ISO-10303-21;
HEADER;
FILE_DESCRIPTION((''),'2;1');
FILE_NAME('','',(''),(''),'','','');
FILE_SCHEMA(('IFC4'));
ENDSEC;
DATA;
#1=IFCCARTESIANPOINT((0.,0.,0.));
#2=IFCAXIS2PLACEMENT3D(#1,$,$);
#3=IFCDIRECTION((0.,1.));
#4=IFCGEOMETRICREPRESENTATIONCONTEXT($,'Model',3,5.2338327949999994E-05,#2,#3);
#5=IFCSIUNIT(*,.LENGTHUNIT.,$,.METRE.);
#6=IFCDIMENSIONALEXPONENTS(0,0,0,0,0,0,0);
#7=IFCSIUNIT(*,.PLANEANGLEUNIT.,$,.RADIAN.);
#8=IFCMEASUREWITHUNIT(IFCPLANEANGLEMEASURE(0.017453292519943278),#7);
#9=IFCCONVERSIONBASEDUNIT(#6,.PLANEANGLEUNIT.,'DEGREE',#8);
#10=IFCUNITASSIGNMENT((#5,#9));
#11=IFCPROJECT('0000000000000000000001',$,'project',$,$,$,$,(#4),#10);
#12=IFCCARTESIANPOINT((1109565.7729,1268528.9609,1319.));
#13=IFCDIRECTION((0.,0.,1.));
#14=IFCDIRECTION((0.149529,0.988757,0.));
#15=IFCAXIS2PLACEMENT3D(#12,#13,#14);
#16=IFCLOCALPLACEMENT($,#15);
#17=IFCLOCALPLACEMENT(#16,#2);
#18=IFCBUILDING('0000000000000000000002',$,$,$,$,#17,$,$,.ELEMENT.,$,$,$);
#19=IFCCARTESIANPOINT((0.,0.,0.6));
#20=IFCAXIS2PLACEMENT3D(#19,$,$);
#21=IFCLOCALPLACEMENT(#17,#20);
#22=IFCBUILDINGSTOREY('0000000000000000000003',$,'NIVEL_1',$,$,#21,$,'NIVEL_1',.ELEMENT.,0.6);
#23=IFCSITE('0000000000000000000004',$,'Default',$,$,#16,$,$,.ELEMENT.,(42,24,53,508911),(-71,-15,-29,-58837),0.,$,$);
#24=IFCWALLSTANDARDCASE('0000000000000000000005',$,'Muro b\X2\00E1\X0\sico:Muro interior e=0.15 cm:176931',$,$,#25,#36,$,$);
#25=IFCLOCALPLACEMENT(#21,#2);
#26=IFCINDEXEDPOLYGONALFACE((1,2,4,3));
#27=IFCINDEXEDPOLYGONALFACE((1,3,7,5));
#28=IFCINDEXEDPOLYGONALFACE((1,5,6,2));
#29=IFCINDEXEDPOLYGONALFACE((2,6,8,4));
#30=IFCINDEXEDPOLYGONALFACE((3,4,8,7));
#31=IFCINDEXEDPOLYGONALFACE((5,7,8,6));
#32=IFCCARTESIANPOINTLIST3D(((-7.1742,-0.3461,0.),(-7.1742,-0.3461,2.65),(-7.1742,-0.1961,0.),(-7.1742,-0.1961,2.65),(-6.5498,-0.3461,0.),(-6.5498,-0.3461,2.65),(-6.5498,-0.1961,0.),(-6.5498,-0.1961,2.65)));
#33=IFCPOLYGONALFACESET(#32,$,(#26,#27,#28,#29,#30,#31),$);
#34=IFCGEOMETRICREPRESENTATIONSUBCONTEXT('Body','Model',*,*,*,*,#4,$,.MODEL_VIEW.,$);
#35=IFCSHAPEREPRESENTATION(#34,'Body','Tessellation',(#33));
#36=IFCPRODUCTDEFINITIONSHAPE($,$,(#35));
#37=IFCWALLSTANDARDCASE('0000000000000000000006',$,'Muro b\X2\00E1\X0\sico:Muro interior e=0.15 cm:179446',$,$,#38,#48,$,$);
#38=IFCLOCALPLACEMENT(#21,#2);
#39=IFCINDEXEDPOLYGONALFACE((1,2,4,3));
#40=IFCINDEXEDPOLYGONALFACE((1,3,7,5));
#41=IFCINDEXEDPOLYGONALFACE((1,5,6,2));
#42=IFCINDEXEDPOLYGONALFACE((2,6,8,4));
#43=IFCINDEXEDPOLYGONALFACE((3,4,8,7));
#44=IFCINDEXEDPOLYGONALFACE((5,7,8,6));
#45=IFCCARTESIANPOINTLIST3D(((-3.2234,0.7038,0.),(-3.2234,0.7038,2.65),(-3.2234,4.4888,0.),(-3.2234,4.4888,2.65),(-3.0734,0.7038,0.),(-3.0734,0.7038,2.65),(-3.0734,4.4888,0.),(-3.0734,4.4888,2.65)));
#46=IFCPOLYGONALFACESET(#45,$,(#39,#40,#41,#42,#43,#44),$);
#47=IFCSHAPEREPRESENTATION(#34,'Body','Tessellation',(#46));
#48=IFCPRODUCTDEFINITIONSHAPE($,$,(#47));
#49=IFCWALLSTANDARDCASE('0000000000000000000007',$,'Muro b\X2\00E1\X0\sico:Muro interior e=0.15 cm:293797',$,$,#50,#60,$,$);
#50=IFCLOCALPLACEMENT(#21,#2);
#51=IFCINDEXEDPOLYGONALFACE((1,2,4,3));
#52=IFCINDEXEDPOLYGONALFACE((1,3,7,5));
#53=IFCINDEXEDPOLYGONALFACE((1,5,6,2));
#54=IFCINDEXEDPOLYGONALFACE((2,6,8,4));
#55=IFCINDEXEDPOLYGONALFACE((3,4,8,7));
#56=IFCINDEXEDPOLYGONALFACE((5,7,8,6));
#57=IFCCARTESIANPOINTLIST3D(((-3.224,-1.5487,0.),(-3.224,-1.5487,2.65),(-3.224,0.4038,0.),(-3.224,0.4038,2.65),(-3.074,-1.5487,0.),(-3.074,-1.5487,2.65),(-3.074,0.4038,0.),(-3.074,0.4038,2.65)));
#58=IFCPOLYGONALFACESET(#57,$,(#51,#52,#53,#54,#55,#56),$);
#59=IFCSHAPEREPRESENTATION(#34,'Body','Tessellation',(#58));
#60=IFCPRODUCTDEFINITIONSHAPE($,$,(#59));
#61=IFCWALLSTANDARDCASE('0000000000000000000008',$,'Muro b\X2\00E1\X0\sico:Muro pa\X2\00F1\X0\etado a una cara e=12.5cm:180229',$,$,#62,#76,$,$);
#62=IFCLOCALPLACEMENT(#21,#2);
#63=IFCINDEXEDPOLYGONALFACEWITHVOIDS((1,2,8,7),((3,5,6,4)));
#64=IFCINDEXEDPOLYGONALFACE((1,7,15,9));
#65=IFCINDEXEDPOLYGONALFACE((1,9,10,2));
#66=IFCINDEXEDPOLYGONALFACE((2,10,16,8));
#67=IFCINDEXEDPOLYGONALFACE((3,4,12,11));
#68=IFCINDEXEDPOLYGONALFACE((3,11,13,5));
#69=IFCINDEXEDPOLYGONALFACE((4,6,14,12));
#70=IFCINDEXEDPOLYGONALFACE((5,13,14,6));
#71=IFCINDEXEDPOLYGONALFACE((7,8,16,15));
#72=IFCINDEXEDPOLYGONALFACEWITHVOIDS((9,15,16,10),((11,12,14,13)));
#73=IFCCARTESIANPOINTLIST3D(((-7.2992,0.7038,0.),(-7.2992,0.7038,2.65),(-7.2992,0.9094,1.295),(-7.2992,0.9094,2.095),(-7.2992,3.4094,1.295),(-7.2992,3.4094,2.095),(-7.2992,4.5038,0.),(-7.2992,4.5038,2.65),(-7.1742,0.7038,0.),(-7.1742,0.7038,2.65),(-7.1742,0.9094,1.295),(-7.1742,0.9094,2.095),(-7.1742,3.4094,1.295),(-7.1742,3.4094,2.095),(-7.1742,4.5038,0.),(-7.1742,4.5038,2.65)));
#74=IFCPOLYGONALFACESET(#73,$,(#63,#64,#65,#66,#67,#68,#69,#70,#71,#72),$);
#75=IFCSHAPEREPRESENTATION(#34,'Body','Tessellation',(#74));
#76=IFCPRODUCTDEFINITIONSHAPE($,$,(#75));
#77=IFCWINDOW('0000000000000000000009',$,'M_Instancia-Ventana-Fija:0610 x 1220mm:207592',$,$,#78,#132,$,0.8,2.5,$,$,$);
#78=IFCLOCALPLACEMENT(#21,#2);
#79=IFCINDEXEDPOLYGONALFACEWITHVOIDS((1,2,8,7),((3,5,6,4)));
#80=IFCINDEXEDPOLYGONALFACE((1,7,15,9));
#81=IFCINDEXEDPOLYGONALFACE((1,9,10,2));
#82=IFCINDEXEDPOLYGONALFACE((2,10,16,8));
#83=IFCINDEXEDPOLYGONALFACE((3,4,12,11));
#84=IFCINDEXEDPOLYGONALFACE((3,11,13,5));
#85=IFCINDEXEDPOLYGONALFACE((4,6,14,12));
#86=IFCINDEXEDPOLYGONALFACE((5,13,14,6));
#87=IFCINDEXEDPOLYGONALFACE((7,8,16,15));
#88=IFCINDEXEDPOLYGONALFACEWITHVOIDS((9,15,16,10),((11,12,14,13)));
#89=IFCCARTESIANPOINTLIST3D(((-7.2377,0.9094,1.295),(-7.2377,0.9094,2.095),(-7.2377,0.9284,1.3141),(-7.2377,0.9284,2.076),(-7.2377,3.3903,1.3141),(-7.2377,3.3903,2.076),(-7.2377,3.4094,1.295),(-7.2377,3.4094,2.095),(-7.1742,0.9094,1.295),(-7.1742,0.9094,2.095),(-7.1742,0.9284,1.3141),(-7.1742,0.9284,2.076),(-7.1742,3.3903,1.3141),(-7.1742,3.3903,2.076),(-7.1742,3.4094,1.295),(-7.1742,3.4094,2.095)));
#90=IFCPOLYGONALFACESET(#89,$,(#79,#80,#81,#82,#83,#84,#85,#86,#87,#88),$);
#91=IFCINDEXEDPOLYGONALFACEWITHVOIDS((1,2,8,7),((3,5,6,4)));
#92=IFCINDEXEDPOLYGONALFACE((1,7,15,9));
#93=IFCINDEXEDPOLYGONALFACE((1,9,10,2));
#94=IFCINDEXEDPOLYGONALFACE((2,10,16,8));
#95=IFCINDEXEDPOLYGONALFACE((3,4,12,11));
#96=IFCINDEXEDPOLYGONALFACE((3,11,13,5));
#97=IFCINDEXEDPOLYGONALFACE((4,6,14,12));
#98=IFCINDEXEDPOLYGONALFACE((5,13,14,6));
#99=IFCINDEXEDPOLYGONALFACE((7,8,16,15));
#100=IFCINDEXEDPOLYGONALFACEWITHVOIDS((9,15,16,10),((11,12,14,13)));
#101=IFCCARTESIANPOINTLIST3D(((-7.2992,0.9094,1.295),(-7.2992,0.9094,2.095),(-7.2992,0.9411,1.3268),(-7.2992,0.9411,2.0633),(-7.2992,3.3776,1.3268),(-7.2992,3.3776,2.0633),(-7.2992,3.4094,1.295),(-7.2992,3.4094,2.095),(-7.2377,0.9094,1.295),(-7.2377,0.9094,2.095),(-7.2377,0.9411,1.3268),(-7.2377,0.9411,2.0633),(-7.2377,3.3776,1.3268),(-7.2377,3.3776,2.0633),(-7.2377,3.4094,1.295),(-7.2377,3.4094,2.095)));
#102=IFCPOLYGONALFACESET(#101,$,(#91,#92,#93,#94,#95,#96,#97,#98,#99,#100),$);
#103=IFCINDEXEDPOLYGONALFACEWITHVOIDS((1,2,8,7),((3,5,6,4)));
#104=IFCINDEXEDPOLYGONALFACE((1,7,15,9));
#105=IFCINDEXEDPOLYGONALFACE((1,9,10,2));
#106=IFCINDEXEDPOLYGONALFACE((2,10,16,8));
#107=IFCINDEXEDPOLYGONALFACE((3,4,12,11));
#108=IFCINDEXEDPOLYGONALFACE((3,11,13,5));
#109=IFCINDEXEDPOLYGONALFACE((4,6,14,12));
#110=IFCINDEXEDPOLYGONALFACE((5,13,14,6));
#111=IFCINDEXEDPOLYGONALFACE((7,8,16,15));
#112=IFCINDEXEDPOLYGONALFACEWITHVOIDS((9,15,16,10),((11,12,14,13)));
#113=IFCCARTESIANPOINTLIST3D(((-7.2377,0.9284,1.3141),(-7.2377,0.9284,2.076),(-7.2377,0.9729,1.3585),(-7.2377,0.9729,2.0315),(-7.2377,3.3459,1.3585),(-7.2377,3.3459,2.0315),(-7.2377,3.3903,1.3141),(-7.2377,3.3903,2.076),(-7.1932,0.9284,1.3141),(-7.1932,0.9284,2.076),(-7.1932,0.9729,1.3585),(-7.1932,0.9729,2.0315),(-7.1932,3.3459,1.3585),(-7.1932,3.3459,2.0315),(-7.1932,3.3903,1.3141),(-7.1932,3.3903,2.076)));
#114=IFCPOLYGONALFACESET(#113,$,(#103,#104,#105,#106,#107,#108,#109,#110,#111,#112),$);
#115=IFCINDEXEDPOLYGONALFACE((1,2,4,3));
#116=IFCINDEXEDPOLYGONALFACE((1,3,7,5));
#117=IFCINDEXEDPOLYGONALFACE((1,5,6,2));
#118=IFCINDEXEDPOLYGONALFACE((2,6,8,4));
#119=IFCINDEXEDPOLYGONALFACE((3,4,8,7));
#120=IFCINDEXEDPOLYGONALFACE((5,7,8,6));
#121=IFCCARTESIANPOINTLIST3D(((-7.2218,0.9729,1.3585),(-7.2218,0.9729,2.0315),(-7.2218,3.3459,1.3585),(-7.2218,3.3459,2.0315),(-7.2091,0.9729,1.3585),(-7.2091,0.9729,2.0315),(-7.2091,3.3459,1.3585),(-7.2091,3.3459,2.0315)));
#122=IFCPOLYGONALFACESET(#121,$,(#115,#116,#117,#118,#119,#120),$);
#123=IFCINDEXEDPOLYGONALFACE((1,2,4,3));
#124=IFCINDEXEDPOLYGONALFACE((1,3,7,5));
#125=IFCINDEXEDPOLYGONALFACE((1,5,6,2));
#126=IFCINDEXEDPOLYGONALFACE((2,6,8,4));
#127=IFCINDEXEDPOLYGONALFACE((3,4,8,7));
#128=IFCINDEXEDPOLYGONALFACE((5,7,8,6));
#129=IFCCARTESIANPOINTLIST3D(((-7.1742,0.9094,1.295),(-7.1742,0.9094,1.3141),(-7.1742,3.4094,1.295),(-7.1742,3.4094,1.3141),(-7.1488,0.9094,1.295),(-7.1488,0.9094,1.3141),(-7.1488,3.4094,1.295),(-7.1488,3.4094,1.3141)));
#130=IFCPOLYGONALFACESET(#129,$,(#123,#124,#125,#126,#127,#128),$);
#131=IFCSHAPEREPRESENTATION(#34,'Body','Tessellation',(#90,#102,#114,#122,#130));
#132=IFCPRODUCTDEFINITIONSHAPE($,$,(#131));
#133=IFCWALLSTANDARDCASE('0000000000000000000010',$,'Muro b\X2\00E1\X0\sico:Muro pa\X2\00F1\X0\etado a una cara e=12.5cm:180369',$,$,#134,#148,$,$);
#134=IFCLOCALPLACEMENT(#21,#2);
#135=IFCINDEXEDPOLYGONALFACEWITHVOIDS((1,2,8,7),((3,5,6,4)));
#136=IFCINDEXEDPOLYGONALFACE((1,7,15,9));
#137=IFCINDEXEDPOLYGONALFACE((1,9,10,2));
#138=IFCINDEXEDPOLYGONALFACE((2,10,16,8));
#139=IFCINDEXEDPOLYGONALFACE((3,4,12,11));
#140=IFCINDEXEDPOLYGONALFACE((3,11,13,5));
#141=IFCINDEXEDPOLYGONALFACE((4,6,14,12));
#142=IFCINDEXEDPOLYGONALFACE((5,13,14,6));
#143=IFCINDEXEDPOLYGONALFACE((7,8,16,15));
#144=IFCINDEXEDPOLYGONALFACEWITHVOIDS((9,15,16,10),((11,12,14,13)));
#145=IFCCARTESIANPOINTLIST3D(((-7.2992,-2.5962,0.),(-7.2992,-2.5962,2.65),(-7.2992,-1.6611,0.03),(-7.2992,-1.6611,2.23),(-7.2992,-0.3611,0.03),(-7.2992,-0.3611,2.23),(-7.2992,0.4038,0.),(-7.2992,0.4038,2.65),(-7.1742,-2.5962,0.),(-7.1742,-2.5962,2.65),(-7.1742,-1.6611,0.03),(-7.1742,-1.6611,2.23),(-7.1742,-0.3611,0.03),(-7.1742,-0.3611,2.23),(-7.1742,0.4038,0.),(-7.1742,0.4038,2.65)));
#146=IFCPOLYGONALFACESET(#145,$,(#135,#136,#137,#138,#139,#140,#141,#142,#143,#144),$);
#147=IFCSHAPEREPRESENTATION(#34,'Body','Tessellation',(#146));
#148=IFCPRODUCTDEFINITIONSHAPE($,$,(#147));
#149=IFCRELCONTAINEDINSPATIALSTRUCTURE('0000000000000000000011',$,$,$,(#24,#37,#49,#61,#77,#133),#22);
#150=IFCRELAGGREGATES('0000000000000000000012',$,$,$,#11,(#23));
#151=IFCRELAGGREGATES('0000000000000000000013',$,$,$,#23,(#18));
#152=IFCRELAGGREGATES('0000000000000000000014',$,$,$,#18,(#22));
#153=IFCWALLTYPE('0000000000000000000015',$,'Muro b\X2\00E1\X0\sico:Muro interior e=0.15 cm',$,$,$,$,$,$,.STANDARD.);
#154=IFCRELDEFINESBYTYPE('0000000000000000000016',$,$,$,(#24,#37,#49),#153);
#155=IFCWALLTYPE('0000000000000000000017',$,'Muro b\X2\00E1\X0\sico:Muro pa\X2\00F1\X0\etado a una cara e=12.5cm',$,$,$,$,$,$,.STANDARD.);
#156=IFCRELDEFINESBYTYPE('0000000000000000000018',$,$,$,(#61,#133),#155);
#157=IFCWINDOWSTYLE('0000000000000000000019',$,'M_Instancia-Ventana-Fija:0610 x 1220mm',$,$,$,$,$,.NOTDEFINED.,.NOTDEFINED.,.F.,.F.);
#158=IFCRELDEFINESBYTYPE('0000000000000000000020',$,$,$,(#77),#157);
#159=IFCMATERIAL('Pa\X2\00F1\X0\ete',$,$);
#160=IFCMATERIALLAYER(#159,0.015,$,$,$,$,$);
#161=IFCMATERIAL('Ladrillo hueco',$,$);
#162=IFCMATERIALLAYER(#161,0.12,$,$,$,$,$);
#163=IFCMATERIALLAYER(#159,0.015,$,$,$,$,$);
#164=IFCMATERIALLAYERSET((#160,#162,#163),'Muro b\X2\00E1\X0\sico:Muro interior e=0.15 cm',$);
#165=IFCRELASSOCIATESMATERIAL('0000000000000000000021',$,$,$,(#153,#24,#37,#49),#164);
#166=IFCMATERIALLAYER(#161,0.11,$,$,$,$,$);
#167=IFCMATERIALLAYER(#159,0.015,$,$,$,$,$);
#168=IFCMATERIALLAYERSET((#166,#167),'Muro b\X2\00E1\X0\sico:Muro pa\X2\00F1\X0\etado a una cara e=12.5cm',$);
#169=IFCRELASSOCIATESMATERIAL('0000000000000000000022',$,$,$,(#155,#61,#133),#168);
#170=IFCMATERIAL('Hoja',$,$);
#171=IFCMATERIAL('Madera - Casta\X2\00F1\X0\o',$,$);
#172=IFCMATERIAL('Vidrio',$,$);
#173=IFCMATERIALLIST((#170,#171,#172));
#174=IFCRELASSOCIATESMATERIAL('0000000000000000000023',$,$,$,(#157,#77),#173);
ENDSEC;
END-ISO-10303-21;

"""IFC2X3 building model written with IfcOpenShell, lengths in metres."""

from ifc_helpers import new_model, entity, si_unit, converted_unit, direction, frame, frame_2d, origin, origin_2d_with_axis, place, context, subcontext, project, spatial, polyline, rectangle, outline, extrude, source, transform, mapped, material, material_list, layer, layer_set, layer_usage, type_object, type_shapes, element, fill, save


model = new_model("IFC2X3")

# Units and contexts
model_context = context("Model", 3, precision=5.2338327949999994e-05, world=origin(), true_north=direction((0.0, 1.0)))
body_context = subcontext(model_context, "Body", "Model", "MODEL_VIEW")
ifc_project = project(units=[si_unit("LENGTHUNIT", "METRE"), converted_unit("PLANEANGLEUNIT", "DEGREE", entity("IfcPlaneAngleMeasure", 0.017453292519943278), si_unit("PLANEANGLEUNIT", "RADIAN"), dimensions=[0, 0, 0, 0, 0, 0, 0])], contexts=[model_context])

# Site, building, storey
site_placement = place(None, frame((1109565.7729, 1268528.9609, 1319.0), z_axis=(0.0, 0.0, 1.0), x_axis=(0.149529, 0.988757, 0.0)))
site = spatial("IfcSite", under=ifc_project, at=site_placement, Name="Default", CompositionType="ELEMENT", RefLatitude=(42, 24, 53, 508911), RefLongitude=(-71, -15, -29, -58837), RefElevation=0.0)
building_placement = place(site_placement, origin())
building = spatial("IfcBuilding", under=site, at=building_placement, CompositionType="ELEMENT")
storey_placement = place(building_placement, frame((0.0, 0.0, 0.6)))
storey = spatial("IfcBuildingStorey", under=building, at=storey_placement, Name="NIVEL_1", LongName="NIVEL_1", CompositionType="ELEMENT", Elevation=0.6)

# Walls
ifc_material_1 = material(Name="Pañete")
ifc_layer_1 = layer(ifc_material_1, 0.015)
ifc_material_2 = material(Name="Ladrillo hueco")
ifc_layer_2 = layer(ifc_material_2, 0.12)
ifc_layer_3 = layer(ifc_material_1, 0.015)
ifc_layer_set_1 = layer_set([ifc_layer_1, ifc_layer_2, ifc_layer_3], Name="Muro básico:Muro interior e=0.15 cm")
ifc_layer_usage_1 = layer_usage(ifc_layer_set_1, "AXIS2", "NEGATIVE", 0.075)
wall_type_1 = type_object("IfcWallType", Name="Muro básico:Muro interior e=0.15 cm", PredefinedType="STANDARD", material=ifc_layer_set_1)
wall_1_placement = place(storey_placement, frame((-6.5498, -0.2711, 0.0), z_axis=(0.0, 0.0, 1.0), x_axis=(-1.0, 0.0, 0.0)))
element("IfcWallStandardCase", 1, at=wall_1_placement, inside=storey, type_object=wall_type_1, material=ifc_layer_usage_1, Name="Muro básico:Muro interior e=0.15 cm:176931", context=body_context, shape_type="SweptSolid", body=[
    extrude(rectangle(XDim=0.6244, YDim=0.15, at=frame_2d((0.3122, 0.0), x_axis=(-1.0, 0.0))), origin(), (0.0, 0.0, 1.0), 2.65),
])
ifc_layer_usage_2 = layer_usage(ifc_layer_set_1, "AXIS2", "NEGATIVE", 0.075)
wall_2_placement = place(storey_placement, frame((-3.1484, 0.7038, 0.0), z_axis=(0.0, 0.0, 1.0), x_axis=(0.0, 1.0, 0.0)))
element("IfcWallStandardCase", 2, at=wall_2_placement, inside=storey, type_object=wall_type_1, material=ifc_layer_usage_2, Name="Muro básico:Muro interior e=0.15 cm:179446", context=body_context, shape_type="SweptSolid", body=[
    extrude(rectangle(XDim=3.785, YDim=0.15, at=frame_2d((1.8925, 0.0), x_axis=(-1.0, 0.0))), origin(), (0.0, 0.0, 1.0), 2.65),
])
ifc_layer_usage_3 = layer_usage(ifc_layer_set_1, "AXIS2", "POSITIVE", -0.075)
wall_3_placement = place(storey_placement, frame((-3.149, -1.5487, 0.0), z_axis=(0.0, 0.0, 1.0), x_axis=(0.0, 1.0, 0.0)))
element("IfcWallStandardCase", 3, at=wall_3_placement, inside=storey, type_object=wall_type_1, material=ifc_layer_usage_3, Name="Muro básico:Muro interior e=0.15 cm:293797", context=body_context, shape_type="SweptSolid", body=[
    extrude(rectangle(XDim=1.9525, YDim=0.15, at=frame_2d((0.9763, 0.0), x_axis=(-1.0, 0.0))), origin(), (0.0, 0.0, 1.0), 2.65),
])

# Wall, opening, window
ifc_layer_4 = layer(ifc_material_2, 0.11)
ifc_layer_5 = layer(ifc_material_1, 0.015)
ifc_layer_set_2 = layer_set([ifc_layer_4, ifc_layer_5], Name="Muro básico:Muro pañetado a una cara e=12.5cm")
ifc_layer_usage_4 = layer_usage(ifc_layer_set_2, "AXIS2", "NEGATIVE", 0.0625)
wall_type_2 = type_object("IfcWallType", Name="Muro básico:Muro pañetado a una cara e=12.5cm", PredefinedType="STANDARD", material=ifc_layer_set_2)
wall_4_placement = place(storey_placement, frame((-7.2367, 0.7038, 0.0), z_axis=(0.0, 0.0, 1.0), x_axis=(0.0, 1.0, 0.0)))
wall_4 = element("IfcWallStandardCase", 4, at=wall_4_placement, inside=storey, type_object=wall_type_2, material=ifc_layer_usage_4, Name="Muro básico:Muro pañetado a una cara e=12.5cm:180229", context=body_context, shape_type="SweptSolid", body=[
    extrude(rectangle(XDim=3.8, YDim=0.125, at=frame_2d((1.9, 0.0), x_axis=(-1.0, 0.0))), origin(), (0.0, 0.0, 1.0), 2.65),
])
opening_1_placement = place(wall_4_placement, frame((2.7056, 0.0625, 1.295)))
opening_1 = element("IfcOpeningElement", 5, at=opening_1_placement, cuts=wall_4, ObjectType="Opening", context=body_context, shape_type="SweptSolid", body=[
    extrude(rectangle(XDim=0.8, YDim=2.5, at=frame_2d((0.4, 1.25), x_axis=(-1.0, 0.0))), frame((0.0, 0.0, 0.0), z_axis=(0.0, -1.0, 0.0), x_axis=(0.0, 0.0, 1.0)), (0.0, 0.0, 1.0), 0.125),
])
ifc_material_3 = material(Name="Hoja")
ifc_material_4 = material(Name="Madera - Castaño")
ifc_material_5 = material(Name="Vidrio")
ifc_material_list_1 = material_list([ifc_material_3, ifc_material_4, ifc_material_5])
window_style = type_object("IfcWindowStyle", Name="M_Instancia-Ventana-Fija:0610 x 1220mm", ConstructionType="NOTDEFINED", OperationType="NOTDEFINED", ParameterTakesPrecedence=False, Sizeable=False, material=ifc_material_list_1)
shared_shape_1 = source(origin(), body_context, "Body", "SweptSolid", [
    extrude(outline(polyline([(-0.4, -1.25), (0.4, -1.25), (0.4, 1.25), (-0.4, 1.25), (-0.4, -1.25)]), holes=[polyline([(-0.3809, -1.2309), (-0.3809, 1.2309), (0.381, 1.2309), (0.381, -1.2309), (-0.3809, -1.2309)])]), frame((1.25, 0.0616, 0.4), z_axis=(0.0, 1.0, 0.0), x_axis=(0.0, 0.0, -1.0)), (0.0, 0.0, 1.0), 0.0635),
    extrude(outline(polyline([(-1.25, -0.4), (1.25, -0.4), (1.25, 0.4), (-1.25, 0.4), (-1.25, -0.4)]), holes=[polyline([(-1.2182, -0.3682), (-1.2182, 0.3683), (1.2182, 0.3683), (1.2182, -0.3682), (-1.2182, -0.3682)])]), frame((1.25, 0.0, 0.4), z_axis=(0.0, 1.0, 0.0), x_axis=(1.0, 0.0, 0.0)), (0.0, 0.0, 1.0), 0.0616),
    extrude(outline(polyline([(-1.2309, -0.381), (1.2309, -0.381), (1.2309, 0.381), (-1.2309, 0.381), (-1.2309, -0.381)]), holes=[polyline([(-1.1865, -0.3365), (-1.1865, 0.3365), (1.1865, 0.3365), (1.1865, -0.3365), (-1.1865, -0.3365)])]), frame((1.25, 0.0616, 0.4), z_axis=(0.0, 1.0, 0.0), x_axis=(1.0, 0.0, 0.0)), (0.0, 0.0, 1.0), 0.0444),
    extrude(rectangle(XDim=0.0127, YDim=2.373, at=origin_2d_with_axis()), frame((1.25, 0.0838, 0.0635), z_axis=(0.0, 0.0, 1.0), x_axis=(0.0, 1.0, 0.0)), (0.0, 0.0, 1.0), 0.673),
    extrude(rectangle(XDim=0.0254, YDim=2.5, at=origin_2d_with_axis()), frame((1.25, 0.1377, 0.0), z_axis=(0.0, 0.0, 1.0), x_axis=(0.0, -1.0, 0.0)), (0.0, 0.0, 1.0), 0.019),
])
type_shapes(window_style, [shared_shape_1])
window_placement = place(opening_1_placement, frame((0.0, 0.0, 0.0), z_axis=(0.0, 0.0, 1.0), x_axis=(-1.0, 0.0, 0.0)))
window = element("IfcWindow", 6, at=window_placement, inside=storey, type_object=window_style, material=ifc_material_list_1, Name="M_Instancia-Ventana-Fija:0610 x 1220mm:207592", OverallHeight=0.8, OverallWidth=2.5, context=body_context, shape_type="MappedRepresentation", body=[
    mapped(shared_shape_1, transform((0.0, 0.0, 0.0), scale=1.0)),
])
fill(opening_1, window)

# Wall, opening
ifc_layer_usage_5 = layer_usage(ifc_layer_set_2, "AXIS2", "POSITIVE", -0.0625)
wall_5_placement = place(storey_placement, frame((-7.2367, 0.4038, 0.0), z_axis=(0.0, 0.0, 1.0), x_axis=(0.0, -1.0, 0.0)))
wall_5 = element("IfcWallStandardCase", 7, at=wall_5_placement, inside=storey, type_object=wall_type_2, material=ifc_layer_usage_5, Name="Muro básico:Muro pañetado a una cara e=12.5cm:180369", context=body_context, shape_type="SweptSolid", body=[
    extrude(rectangle(XDim=3.0, YDim=0.125, at=frame_2d((1.5, 0.0), x_axis=(-1.0, 0.0))), origin(), (0.0, 0.0, 1.0), 2.65),
])
opening_2_placement = place(wall_5_placement, frame((0.7649, -0.0625, 0.03)))
element("IfcOpeningElement", 8, at=opening_2_placement, cuts=wall_5, ObjectType="Opening", context=body_context, shape_type="SweptSolid", body=[
    extrude(rectangle(XDim=2.2, YDim=1.3, at=frame_2d((1.1, 0.65), x_axis=(1.0, 0.0))), frame((0.0, 0.0, 0.0), z_axis=(0.0, 1.0, 0.0), x_axis=(0.0, 0.0, 1.0)), (0.0, 0.0, 1.0), 0.125),
])

save(model, "model.ifc")
